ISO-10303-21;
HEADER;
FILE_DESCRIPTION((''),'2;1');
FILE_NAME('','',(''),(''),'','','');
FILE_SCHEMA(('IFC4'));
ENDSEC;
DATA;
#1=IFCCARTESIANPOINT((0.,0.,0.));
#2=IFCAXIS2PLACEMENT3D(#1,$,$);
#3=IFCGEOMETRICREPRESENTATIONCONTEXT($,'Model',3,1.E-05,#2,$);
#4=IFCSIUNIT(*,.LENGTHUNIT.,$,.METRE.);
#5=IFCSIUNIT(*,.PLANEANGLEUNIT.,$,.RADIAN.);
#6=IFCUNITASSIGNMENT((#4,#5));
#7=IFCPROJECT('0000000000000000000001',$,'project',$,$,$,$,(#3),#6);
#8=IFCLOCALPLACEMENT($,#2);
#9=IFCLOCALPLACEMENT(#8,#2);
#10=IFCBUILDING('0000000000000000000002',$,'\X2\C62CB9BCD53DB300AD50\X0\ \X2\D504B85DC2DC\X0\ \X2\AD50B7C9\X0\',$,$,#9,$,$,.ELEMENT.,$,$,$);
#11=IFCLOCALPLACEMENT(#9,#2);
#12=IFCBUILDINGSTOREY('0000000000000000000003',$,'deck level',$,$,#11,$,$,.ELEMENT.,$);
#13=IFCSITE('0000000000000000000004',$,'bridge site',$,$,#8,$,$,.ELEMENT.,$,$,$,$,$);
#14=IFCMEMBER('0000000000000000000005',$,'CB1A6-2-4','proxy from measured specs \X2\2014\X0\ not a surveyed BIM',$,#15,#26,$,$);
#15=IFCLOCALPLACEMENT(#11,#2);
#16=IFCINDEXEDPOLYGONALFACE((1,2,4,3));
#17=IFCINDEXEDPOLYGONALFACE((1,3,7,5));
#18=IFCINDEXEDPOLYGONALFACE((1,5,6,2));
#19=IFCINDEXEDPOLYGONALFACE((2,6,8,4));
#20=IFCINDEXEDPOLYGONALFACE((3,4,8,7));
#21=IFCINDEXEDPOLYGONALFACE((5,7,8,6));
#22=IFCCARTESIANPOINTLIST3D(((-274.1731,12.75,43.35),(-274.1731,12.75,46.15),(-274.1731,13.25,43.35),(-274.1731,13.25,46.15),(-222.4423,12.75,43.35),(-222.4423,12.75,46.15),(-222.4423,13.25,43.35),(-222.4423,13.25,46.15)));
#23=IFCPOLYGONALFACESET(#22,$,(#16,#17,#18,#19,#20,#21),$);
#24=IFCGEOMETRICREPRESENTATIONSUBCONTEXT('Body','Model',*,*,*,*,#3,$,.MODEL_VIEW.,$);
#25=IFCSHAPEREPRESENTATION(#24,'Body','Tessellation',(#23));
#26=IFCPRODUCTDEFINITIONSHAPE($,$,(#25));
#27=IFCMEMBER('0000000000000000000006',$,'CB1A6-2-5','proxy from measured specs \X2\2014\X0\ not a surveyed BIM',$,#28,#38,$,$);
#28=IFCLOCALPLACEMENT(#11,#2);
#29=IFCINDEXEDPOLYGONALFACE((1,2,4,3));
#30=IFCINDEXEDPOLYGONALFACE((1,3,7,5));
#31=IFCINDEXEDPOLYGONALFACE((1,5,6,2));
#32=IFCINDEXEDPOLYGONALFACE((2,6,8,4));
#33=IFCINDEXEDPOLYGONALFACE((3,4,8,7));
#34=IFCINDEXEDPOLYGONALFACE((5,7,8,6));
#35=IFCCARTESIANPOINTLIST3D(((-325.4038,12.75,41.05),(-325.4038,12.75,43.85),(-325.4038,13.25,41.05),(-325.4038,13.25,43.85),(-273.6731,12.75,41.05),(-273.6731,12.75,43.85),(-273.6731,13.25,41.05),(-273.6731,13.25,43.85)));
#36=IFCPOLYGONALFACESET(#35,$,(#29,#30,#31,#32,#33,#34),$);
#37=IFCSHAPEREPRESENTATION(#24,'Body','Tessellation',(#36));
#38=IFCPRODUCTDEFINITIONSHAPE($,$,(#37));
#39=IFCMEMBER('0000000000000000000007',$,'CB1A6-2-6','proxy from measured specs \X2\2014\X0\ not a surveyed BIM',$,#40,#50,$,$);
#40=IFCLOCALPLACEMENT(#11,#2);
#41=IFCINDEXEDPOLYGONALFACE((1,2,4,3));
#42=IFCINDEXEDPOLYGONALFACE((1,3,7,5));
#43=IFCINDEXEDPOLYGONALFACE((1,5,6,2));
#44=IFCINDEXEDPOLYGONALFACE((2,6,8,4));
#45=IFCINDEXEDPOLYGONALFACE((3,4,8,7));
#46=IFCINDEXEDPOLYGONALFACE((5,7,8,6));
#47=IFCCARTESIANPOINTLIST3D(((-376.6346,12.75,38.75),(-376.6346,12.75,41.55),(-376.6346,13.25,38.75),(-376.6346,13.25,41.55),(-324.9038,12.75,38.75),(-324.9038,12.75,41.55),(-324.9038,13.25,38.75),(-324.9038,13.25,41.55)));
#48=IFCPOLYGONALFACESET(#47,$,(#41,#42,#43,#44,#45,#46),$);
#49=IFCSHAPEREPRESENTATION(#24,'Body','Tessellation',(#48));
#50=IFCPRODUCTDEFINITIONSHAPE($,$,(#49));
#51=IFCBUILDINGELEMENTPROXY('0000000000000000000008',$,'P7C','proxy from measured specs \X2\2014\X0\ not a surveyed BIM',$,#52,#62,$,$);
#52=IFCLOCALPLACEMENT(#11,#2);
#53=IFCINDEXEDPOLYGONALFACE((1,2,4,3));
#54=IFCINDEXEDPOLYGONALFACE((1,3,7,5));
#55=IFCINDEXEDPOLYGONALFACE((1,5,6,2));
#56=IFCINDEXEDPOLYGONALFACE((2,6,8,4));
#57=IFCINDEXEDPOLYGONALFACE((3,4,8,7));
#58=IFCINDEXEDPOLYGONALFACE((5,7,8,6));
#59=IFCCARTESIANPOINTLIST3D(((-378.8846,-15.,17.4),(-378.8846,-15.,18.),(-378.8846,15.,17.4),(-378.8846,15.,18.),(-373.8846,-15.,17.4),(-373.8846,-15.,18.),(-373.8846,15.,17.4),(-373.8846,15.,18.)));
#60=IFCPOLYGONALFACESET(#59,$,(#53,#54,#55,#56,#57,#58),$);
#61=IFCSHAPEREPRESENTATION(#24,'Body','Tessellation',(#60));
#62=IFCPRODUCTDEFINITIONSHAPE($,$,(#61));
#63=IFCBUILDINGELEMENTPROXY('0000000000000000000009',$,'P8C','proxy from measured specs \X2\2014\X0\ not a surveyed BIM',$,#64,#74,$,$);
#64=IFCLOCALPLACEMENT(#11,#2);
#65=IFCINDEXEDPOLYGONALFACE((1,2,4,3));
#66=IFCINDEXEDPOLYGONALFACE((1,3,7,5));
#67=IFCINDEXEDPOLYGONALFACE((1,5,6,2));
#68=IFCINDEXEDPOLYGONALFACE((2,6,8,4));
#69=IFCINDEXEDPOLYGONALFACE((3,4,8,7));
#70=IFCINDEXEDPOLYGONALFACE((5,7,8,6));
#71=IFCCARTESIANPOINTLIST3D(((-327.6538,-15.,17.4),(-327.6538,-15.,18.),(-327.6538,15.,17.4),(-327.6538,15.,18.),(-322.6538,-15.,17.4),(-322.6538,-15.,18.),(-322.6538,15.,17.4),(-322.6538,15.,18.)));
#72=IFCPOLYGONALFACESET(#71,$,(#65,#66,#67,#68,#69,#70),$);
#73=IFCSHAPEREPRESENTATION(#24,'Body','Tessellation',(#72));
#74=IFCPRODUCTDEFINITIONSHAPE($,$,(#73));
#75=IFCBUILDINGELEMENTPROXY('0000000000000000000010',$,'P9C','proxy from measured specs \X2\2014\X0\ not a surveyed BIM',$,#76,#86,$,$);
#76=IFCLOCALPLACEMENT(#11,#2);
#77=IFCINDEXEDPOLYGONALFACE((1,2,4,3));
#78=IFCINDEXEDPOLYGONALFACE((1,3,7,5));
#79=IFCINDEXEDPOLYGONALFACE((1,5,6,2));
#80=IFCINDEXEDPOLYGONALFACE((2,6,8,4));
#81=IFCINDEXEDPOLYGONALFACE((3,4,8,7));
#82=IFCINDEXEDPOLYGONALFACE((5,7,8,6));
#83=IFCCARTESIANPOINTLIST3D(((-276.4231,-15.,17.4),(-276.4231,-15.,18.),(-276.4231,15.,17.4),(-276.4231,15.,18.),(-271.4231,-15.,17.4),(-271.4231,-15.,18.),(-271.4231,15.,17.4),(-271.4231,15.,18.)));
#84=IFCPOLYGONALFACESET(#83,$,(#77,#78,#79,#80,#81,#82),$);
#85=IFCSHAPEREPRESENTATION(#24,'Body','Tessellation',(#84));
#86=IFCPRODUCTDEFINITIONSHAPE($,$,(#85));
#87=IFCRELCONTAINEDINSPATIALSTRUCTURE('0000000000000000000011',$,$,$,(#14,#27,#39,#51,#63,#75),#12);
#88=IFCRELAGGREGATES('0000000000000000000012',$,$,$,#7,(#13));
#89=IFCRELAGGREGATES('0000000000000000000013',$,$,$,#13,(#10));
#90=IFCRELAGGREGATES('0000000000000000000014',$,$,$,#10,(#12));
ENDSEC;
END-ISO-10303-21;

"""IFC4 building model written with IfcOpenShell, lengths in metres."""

from ifc_helpers import new_model, si_unit, frame, origin, origin_2d, place, context, subcontext, project, spatial, rectangle, extrude, element, save


model = new_model("IFC4")

# Units and contexts
model_context = context("Model", 3, precision=1e-05, world=origin())
body_context = subcontext(model_context, "Body", "Model", "MODEL_VIEW")
ifc_project = project(units=[si_unit("LENGTHUNIT", "METRE"), si_unit("PLANEANGLEUNIT", "RADIAN")], contexts=[model_context])

# Site, building, storey
site_placement = place(None, origin())
site = spatial("IfcSite", under=ifc_project, at=site_placement, Name="bridge site", CompositionType="ELEMENT")
building_placement = place(site_placement, origin())
building = spatial("IfcBuilding", under=site, at=building_placement, Name="올림픽대교 프록시 교량", CompositionType="ELEMENT")
storey_placement = place(building_placement, origin())
storey = spatial("IfcBuildingStorey", under=building, at=storey_placement, Name="deck level", CompositionType="ELEMENT")

# Members
member_1_placement = place(storey_placement, frame((-248.3077, 13.0, 43.35)))
element("IfcMember", 1, at=member_1_placement, inside=storey, Name="CB1A6-2-4", Description="proxy from measured specs — not a surveyed BIM", context=body_context, shape_type="SweptSolid", body=[
    extrude(rectangle(XDim=51.7308, YDim=0.5, at=origin_2d()), origin(), (0.0, 0.0, 1.0), 2.8),
])
for number, where, name in (
    (2, (-299.5385, 13.0, 41.05), "CB1A6-2-5"),
    (3, (-350.7692, 13.0, 38.75), "CB1A6-2-6"),
):
    element("IfcMember", number, at=place(storey_placement, frame(where)), inside=storey, Name=name, Description="proxy from measured specs — not a surveyed BIM", context=body_context, shape_type="SweptSolid", body=[
        extrude(rectangle(XDim=51.7308, YDim=0.5, at=origin_2d()), origin(), (0.0, 0.0, 1.0), 2.8),
    ])

# Building element proxies
for number, where, name in (
    (4, (-376.3846, 0.0, 17.4), "P7C"),
    (5, (-325.1538, 0.0, 17.4), "P8C"),
    (6, (-273.9231, 0.0, 17.4), "P9C"),
):
    element("IfcBuildingElementProxy", number, at=place(storey_placement, frame(where)), inside=storey, Name=name, Description="proxy from measured specs — not a surveyed BIM", context=body_context, shape_type="SweptSolid", body=[
        extrude(rectangle(XDim=5.0, YDim=30.0, at=origin_2d()), origin(), (0.0, 0.0, 1.0), 0.6),
    ])

save(model, "model.ifc")
